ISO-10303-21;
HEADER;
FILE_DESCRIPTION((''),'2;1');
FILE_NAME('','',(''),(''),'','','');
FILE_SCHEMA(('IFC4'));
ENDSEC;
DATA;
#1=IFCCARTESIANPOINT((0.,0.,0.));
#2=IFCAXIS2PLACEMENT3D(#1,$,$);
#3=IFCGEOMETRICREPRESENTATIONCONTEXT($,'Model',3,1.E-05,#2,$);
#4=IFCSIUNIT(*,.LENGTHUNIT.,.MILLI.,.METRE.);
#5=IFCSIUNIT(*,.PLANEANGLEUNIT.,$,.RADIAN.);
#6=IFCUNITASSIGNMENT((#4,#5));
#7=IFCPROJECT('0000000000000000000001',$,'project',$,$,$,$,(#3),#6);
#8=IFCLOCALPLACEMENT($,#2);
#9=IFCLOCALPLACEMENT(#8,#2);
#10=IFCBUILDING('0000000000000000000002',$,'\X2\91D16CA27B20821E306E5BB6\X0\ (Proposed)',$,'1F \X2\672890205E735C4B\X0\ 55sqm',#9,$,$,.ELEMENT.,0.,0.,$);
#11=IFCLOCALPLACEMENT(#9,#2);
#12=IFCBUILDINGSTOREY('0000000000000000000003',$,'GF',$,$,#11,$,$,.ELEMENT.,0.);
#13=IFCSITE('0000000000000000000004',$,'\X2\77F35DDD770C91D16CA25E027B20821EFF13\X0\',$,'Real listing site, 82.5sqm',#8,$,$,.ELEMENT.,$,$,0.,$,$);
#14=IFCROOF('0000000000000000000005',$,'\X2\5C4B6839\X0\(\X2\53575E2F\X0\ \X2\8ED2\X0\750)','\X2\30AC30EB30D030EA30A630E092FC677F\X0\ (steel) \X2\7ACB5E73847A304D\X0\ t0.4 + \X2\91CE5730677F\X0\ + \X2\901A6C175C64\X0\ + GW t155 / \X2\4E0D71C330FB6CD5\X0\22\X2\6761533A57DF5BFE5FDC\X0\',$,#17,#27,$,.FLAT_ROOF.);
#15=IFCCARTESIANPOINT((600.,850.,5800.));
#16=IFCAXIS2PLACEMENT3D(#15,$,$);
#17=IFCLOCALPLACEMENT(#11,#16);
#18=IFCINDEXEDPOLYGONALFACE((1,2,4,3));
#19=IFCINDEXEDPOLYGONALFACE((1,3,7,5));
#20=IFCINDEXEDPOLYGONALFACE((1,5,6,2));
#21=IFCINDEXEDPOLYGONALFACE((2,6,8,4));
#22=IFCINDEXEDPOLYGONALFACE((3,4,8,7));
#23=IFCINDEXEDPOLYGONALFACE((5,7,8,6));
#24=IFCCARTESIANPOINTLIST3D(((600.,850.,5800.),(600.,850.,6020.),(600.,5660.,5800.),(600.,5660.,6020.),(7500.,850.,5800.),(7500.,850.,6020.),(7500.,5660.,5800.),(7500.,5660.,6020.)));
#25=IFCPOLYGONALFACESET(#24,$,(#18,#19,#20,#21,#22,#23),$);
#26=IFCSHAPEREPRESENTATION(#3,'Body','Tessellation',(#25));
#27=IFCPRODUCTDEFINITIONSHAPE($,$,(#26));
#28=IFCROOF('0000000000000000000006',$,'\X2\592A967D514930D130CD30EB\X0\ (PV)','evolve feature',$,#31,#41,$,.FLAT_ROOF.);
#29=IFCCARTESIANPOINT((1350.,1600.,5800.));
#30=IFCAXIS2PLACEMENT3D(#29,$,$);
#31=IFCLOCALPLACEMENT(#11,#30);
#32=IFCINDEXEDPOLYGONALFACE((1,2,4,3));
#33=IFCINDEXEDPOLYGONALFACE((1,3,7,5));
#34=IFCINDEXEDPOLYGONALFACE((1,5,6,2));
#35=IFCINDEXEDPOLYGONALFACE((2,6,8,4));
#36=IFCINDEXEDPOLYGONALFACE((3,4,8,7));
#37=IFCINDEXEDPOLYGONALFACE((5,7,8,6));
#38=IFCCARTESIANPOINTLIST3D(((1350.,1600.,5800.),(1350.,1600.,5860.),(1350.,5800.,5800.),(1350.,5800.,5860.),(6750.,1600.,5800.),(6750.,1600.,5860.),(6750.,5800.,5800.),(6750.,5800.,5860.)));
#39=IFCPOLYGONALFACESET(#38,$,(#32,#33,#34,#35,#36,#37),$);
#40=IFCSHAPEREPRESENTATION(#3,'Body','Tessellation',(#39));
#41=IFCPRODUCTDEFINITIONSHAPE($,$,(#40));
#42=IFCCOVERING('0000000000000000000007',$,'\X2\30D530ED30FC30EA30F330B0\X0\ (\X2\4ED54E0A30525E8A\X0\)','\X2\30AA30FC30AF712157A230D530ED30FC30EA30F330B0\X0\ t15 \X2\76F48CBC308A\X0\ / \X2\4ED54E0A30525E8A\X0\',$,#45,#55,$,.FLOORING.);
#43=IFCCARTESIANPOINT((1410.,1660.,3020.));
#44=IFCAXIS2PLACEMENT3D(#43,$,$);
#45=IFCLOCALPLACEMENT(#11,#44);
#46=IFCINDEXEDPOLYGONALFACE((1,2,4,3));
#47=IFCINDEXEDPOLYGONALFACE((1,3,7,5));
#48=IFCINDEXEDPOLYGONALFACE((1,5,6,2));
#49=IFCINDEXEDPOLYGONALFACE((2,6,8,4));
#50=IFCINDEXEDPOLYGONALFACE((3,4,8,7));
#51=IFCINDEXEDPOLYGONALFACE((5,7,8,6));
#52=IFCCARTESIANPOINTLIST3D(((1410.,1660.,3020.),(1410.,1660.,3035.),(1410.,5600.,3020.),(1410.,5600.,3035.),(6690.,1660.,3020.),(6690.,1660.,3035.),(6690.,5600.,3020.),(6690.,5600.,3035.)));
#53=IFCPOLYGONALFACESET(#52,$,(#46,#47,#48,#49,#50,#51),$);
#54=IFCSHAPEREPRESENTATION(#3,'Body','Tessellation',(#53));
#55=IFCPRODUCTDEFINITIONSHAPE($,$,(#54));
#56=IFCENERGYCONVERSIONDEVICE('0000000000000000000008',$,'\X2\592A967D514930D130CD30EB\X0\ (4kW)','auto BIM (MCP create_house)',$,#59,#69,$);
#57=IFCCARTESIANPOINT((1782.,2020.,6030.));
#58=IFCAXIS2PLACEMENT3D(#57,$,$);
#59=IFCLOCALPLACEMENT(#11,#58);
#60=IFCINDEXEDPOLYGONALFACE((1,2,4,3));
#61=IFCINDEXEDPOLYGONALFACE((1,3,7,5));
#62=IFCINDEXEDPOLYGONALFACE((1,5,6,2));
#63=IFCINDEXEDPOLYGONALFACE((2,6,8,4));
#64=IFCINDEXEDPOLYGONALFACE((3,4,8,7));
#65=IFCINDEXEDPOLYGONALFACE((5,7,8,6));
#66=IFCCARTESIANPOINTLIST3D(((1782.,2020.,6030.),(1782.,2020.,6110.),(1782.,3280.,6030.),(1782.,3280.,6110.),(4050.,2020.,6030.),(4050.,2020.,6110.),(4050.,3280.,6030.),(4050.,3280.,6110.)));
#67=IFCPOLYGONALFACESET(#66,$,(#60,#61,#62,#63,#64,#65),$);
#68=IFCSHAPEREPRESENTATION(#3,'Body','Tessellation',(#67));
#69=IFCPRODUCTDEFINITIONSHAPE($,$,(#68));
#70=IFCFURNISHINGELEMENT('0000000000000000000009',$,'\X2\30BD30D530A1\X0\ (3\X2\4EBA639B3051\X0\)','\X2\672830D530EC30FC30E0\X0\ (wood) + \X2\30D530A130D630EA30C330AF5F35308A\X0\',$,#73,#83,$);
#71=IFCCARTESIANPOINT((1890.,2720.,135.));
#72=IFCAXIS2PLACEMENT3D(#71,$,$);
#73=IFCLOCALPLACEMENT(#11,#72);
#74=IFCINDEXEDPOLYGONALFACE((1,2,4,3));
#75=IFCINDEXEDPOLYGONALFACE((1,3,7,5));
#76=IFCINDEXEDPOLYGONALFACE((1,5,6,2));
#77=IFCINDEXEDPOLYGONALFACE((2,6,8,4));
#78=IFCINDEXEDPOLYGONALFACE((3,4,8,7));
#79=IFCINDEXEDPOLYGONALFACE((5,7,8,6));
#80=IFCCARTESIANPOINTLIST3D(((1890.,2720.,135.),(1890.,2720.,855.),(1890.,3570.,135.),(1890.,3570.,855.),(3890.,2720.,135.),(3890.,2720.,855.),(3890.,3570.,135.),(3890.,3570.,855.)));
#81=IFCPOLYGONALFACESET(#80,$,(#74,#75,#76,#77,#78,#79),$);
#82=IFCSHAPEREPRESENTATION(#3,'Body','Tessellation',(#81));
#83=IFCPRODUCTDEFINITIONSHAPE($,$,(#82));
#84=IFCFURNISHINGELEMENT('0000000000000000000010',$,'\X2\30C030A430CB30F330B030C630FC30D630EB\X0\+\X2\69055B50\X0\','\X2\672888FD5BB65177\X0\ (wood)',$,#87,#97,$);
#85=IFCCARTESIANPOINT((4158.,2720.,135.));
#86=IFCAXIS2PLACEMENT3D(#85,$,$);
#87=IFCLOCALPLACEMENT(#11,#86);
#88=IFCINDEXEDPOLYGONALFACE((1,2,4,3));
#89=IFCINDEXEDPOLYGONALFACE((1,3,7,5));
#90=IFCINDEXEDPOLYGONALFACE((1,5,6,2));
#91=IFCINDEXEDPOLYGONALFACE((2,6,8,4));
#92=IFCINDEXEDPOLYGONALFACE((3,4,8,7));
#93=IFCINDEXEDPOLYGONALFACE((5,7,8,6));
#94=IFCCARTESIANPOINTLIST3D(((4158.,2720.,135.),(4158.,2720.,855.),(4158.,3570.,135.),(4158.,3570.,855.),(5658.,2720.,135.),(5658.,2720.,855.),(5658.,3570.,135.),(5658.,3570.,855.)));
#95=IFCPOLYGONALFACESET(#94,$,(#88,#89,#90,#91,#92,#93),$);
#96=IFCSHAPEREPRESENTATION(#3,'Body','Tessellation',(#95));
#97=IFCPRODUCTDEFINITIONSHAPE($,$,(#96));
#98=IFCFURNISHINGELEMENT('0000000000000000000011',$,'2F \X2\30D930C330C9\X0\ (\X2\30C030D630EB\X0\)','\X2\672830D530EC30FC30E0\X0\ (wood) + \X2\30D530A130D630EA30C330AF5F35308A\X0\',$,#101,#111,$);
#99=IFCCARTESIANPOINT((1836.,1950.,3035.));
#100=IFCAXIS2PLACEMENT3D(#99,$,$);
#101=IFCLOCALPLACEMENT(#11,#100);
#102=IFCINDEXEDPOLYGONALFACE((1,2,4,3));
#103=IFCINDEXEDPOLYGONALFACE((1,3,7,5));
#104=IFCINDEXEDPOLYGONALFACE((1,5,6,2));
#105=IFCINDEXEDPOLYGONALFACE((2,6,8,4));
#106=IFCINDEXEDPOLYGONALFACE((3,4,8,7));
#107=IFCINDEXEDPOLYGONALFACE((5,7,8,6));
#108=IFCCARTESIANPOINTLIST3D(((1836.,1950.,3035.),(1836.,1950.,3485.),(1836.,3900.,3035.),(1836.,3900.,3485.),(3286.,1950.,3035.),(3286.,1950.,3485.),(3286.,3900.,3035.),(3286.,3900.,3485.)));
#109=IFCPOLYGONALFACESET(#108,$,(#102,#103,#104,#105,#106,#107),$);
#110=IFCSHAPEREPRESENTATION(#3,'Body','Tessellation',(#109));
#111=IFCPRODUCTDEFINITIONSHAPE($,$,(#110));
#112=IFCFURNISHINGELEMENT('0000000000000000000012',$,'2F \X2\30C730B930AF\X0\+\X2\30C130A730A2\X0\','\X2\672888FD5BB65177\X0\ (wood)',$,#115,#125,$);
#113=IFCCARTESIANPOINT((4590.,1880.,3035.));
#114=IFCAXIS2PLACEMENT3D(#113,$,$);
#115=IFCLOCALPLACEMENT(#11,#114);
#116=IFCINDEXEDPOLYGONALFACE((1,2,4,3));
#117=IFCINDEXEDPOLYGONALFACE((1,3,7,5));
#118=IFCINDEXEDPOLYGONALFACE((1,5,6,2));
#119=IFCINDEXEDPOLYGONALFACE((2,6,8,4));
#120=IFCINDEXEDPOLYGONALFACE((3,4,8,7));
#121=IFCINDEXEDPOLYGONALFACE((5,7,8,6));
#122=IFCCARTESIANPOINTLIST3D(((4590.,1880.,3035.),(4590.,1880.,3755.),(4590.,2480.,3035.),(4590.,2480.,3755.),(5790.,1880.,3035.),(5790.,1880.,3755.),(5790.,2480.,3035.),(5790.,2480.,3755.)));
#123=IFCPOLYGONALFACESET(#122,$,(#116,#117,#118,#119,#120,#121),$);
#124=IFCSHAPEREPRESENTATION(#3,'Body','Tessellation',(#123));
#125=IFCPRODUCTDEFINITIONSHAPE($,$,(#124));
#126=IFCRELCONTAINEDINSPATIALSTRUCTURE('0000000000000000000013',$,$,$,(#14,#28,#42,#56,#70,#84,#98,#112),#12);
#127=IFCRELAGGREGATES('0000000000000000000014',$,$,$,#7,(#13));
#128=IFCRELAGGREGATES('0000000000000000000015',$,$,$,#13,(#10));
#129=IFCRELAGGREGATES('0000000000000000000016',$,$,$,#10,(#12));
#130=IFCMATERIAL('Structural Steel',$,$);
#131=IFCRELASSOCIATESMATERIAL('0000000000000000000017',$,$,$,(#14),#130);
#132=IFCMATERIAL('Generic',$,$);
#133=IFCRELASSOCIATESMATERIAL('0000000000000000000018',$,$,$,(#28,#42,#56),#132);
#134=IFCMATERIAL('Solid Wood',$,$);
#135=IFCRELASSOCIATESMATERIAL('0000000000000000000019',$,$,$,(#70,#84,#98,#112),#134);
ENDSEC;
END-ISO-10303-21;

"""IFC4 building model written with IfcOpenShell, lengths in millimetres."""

from ifc_helpers import new_model, si_unit, frame, frame_2d, origin, place, context, project, spatial, rectangle, extrude, material, element, save


model = new_model("IFC4")

# Units and contexts
model_context = context("Model", 3, precision=1e-05, world=origin())
ifc_project = project(units=[si_unit("LENGTHUNIT", "METRE", prefix="MILLI"), si_unit("PLANEANGLEUNIT", "RADIAN")], contexts=[model_context])

# Site, building, storey
site_placement = place(None, origin())
site = spatial("IfcSite", under=ifc_project, at=site_placement, Name="石川県金沢市笠舞３", ObjectType="Real listing site, 82.5sqm", CompositionType="ELEMENT", RefElevation=0.0)
building_placement = place(site_placement, origin())
building = spatial("IfcBuilding", under=site, at=building_placement, Name="金沢笠舞の家 (Proposed)", ObjectType="1F 木造平屋 55sqm", CompositionType="ELEMENT", ElevationOfRefHeight=0.0, ElevationOfTerrain=0.0)
storey_placement = place(building_placement, origin())
storey = spatial("IfcBuildingStorey", under=building, at=storey_placement, Name="GF", CompositionType="ELEMENT", Elevation=0.0)

# Shared definitions
ifc_material_1 = material(Name="Solid Wood")

# Shared definitions
ifc_material_2 = material(Name="Generic")

# Roofs
ifc_material_3 = material(Name="Structural Steel")
for number, where, name in (
    (1, (600.0, 850.0, 5800.0), "屋根(南帯 軒750)"),
):
    element("IfcRoof", number, at=place(storey_placement, frame(where)), inside=storey, material=ifc_material_3, Name=name, Description="ガルバリウム鋼板 (steel) 立平葺き t0.4 + 野地板 + 通気層 + GW t155 / 不燃・法22条区域対応", PredefinedType="FLAT_ROOF", context=model_context, shape_type="SweptSolid", body=[
        extrude(rectangle(XDim=6900.0, YDim=4810.0, at=frame_2d((3450.0, 2405.0))), frame((600.0, 850.0, 5800.0)), (0.0, 0.0, 1.0), 220.0),
    ])
roof_placement = place(storey_placement, frame((1350.0, 1600.0, 5800.0)))
element("IfcRoof", 2, at=roof_placement, inside=storey, material=ifc_material_2, Name="太陽光パネル (PV)", Description="evolve feature", PredefinedType="FLAT_ROOF", context=model_context, shape_type="SweptSolid", body=[
    extrude(rectangle(XDim=5400.0, YDim=4200.0, at=frame_2d((2700.0, 2100.0))), frame((1350.0, 1600.0, 5800.0)), (0.0, 0.0, 1.0), 60.0),
])

# Covering
covering_placement = place(storey_placement, frame((1410.0, 1660.0, 3020.0)))
element("IfcCovering", 3, at=covering_placement, inside=storey, material=ifc_material_2, Name="フローリング (仕上げ床)", Description="オーク無垢フローリング t15 直貼り / 仕上げ床", PredefinedType="FLOORING", context=model_context, shape_type="SweptSolid", body=[
    extrude(rectangle(XDim=5280.0, YDim=3940.0, at=frame_2d((2640.0, 1970.0))), frame((1410.0, 1660.0, 3020.0)), (0.0, 0.0, 1.0), 15.0),
])

# Energy conversion device
energy_conversion_device_placement = place(storey_placement, frame((1782.0, 2020.0, 6030.0)))
element("IfcEnergyConversionDevice", 4, at=energy_conversion_device_placement, inside=storey, material=ifc_material_2, Name="太陽光パネル (4kW)", Description="auto BIM (MCP create_house)", context=model_context, shape_type="SweptSolid", body=[
    extrude(rectangle(XDim=2268.0, YDim=1260.0, at=frame_2d((1134.0, 630.0))), frame((1782.0, 2020.0, 6030.0)), (0.0, 0.0, 1.0), 80.0),
])

# Furnishing elements
furnishing_1_placement = place(storey_placement, frame((1890.0, 2720.0, 135.0)))
element("IfcFurnishingElement", 5, at=furnishing_1_placement, inside=storey, material=ifc_material_1, Name="ソファ (3人掛け)", Description="木フレーム (wood) + ファブリック張り", context=model_context, shape_type="SweptSolid", body=[
    extrude(rectangle(XDim=2000.0, YDim=850.0, at=frame_2d((1000.0, 425.0))), frame((1890.0, 2720.0, 135.0)), (0.0, 0.0, 1.0), 720.0),
])
furnishing_2_placement = place(storey_placement, frame((4158.0, 2720.0, 135.0)))
element("IfcFurnishingElement", 6, at=furnishing_2_placement, inside=storey, material=ifc_material_1, Name="ダイニングテーブル+椅子", Description="木製家具 (wood)", context=model_context, shape_type="SweptSolid", body=[
    extrude(rectangle(XDim=1500.0, YDim=850.0, at=frame_2d((750.0, 425.0))), frame((4158.0, 2720.0, 135.0)), (0.0, 0.0, 1.0), 720.0),
])
furnishing_3_placement = place(storey_placement, frame((1836.0, 1950.0, 3035.0)))
element("IfcFurnishingElement", 7, at=furnishing_3_placement, inside=storey, material=ifc_material_1, Name="2F ベッド (ダブル)", Description="木フレーム (wood) + ファブリック張り", context=model_context, shape_type="SweptSolid", body=[
    extrude(rectangle(XDim=1450.0, YDim=1950.0, at=frame_2d((725.0, 975.0))), frame((1836.0, 1950.0, 3035.0)), (0.0, 0.0, 1.0), 450.0),
])
furnishing_4_placement = place(storey_placement, frame((4590.0, 1880.0, 3035.0)))
element("IfcFurnishingElement", 8, at=furnishing_4_placement, inside=storey, material=ifc_material_1, Name="2F デスク+チェア", Description="木製家具 (wood)", context=model_context, shape_type="SweptSolid", body=[
    extrude(rectangle(XDim=1200.0, YDim=600.0, at=frame_2d((600.0, 300.0))), frame((4590.0, 1880.0, 3035.0)), (0.0, 0.0, 1.0), 720.0),
])

save(model, "model.ifc")
